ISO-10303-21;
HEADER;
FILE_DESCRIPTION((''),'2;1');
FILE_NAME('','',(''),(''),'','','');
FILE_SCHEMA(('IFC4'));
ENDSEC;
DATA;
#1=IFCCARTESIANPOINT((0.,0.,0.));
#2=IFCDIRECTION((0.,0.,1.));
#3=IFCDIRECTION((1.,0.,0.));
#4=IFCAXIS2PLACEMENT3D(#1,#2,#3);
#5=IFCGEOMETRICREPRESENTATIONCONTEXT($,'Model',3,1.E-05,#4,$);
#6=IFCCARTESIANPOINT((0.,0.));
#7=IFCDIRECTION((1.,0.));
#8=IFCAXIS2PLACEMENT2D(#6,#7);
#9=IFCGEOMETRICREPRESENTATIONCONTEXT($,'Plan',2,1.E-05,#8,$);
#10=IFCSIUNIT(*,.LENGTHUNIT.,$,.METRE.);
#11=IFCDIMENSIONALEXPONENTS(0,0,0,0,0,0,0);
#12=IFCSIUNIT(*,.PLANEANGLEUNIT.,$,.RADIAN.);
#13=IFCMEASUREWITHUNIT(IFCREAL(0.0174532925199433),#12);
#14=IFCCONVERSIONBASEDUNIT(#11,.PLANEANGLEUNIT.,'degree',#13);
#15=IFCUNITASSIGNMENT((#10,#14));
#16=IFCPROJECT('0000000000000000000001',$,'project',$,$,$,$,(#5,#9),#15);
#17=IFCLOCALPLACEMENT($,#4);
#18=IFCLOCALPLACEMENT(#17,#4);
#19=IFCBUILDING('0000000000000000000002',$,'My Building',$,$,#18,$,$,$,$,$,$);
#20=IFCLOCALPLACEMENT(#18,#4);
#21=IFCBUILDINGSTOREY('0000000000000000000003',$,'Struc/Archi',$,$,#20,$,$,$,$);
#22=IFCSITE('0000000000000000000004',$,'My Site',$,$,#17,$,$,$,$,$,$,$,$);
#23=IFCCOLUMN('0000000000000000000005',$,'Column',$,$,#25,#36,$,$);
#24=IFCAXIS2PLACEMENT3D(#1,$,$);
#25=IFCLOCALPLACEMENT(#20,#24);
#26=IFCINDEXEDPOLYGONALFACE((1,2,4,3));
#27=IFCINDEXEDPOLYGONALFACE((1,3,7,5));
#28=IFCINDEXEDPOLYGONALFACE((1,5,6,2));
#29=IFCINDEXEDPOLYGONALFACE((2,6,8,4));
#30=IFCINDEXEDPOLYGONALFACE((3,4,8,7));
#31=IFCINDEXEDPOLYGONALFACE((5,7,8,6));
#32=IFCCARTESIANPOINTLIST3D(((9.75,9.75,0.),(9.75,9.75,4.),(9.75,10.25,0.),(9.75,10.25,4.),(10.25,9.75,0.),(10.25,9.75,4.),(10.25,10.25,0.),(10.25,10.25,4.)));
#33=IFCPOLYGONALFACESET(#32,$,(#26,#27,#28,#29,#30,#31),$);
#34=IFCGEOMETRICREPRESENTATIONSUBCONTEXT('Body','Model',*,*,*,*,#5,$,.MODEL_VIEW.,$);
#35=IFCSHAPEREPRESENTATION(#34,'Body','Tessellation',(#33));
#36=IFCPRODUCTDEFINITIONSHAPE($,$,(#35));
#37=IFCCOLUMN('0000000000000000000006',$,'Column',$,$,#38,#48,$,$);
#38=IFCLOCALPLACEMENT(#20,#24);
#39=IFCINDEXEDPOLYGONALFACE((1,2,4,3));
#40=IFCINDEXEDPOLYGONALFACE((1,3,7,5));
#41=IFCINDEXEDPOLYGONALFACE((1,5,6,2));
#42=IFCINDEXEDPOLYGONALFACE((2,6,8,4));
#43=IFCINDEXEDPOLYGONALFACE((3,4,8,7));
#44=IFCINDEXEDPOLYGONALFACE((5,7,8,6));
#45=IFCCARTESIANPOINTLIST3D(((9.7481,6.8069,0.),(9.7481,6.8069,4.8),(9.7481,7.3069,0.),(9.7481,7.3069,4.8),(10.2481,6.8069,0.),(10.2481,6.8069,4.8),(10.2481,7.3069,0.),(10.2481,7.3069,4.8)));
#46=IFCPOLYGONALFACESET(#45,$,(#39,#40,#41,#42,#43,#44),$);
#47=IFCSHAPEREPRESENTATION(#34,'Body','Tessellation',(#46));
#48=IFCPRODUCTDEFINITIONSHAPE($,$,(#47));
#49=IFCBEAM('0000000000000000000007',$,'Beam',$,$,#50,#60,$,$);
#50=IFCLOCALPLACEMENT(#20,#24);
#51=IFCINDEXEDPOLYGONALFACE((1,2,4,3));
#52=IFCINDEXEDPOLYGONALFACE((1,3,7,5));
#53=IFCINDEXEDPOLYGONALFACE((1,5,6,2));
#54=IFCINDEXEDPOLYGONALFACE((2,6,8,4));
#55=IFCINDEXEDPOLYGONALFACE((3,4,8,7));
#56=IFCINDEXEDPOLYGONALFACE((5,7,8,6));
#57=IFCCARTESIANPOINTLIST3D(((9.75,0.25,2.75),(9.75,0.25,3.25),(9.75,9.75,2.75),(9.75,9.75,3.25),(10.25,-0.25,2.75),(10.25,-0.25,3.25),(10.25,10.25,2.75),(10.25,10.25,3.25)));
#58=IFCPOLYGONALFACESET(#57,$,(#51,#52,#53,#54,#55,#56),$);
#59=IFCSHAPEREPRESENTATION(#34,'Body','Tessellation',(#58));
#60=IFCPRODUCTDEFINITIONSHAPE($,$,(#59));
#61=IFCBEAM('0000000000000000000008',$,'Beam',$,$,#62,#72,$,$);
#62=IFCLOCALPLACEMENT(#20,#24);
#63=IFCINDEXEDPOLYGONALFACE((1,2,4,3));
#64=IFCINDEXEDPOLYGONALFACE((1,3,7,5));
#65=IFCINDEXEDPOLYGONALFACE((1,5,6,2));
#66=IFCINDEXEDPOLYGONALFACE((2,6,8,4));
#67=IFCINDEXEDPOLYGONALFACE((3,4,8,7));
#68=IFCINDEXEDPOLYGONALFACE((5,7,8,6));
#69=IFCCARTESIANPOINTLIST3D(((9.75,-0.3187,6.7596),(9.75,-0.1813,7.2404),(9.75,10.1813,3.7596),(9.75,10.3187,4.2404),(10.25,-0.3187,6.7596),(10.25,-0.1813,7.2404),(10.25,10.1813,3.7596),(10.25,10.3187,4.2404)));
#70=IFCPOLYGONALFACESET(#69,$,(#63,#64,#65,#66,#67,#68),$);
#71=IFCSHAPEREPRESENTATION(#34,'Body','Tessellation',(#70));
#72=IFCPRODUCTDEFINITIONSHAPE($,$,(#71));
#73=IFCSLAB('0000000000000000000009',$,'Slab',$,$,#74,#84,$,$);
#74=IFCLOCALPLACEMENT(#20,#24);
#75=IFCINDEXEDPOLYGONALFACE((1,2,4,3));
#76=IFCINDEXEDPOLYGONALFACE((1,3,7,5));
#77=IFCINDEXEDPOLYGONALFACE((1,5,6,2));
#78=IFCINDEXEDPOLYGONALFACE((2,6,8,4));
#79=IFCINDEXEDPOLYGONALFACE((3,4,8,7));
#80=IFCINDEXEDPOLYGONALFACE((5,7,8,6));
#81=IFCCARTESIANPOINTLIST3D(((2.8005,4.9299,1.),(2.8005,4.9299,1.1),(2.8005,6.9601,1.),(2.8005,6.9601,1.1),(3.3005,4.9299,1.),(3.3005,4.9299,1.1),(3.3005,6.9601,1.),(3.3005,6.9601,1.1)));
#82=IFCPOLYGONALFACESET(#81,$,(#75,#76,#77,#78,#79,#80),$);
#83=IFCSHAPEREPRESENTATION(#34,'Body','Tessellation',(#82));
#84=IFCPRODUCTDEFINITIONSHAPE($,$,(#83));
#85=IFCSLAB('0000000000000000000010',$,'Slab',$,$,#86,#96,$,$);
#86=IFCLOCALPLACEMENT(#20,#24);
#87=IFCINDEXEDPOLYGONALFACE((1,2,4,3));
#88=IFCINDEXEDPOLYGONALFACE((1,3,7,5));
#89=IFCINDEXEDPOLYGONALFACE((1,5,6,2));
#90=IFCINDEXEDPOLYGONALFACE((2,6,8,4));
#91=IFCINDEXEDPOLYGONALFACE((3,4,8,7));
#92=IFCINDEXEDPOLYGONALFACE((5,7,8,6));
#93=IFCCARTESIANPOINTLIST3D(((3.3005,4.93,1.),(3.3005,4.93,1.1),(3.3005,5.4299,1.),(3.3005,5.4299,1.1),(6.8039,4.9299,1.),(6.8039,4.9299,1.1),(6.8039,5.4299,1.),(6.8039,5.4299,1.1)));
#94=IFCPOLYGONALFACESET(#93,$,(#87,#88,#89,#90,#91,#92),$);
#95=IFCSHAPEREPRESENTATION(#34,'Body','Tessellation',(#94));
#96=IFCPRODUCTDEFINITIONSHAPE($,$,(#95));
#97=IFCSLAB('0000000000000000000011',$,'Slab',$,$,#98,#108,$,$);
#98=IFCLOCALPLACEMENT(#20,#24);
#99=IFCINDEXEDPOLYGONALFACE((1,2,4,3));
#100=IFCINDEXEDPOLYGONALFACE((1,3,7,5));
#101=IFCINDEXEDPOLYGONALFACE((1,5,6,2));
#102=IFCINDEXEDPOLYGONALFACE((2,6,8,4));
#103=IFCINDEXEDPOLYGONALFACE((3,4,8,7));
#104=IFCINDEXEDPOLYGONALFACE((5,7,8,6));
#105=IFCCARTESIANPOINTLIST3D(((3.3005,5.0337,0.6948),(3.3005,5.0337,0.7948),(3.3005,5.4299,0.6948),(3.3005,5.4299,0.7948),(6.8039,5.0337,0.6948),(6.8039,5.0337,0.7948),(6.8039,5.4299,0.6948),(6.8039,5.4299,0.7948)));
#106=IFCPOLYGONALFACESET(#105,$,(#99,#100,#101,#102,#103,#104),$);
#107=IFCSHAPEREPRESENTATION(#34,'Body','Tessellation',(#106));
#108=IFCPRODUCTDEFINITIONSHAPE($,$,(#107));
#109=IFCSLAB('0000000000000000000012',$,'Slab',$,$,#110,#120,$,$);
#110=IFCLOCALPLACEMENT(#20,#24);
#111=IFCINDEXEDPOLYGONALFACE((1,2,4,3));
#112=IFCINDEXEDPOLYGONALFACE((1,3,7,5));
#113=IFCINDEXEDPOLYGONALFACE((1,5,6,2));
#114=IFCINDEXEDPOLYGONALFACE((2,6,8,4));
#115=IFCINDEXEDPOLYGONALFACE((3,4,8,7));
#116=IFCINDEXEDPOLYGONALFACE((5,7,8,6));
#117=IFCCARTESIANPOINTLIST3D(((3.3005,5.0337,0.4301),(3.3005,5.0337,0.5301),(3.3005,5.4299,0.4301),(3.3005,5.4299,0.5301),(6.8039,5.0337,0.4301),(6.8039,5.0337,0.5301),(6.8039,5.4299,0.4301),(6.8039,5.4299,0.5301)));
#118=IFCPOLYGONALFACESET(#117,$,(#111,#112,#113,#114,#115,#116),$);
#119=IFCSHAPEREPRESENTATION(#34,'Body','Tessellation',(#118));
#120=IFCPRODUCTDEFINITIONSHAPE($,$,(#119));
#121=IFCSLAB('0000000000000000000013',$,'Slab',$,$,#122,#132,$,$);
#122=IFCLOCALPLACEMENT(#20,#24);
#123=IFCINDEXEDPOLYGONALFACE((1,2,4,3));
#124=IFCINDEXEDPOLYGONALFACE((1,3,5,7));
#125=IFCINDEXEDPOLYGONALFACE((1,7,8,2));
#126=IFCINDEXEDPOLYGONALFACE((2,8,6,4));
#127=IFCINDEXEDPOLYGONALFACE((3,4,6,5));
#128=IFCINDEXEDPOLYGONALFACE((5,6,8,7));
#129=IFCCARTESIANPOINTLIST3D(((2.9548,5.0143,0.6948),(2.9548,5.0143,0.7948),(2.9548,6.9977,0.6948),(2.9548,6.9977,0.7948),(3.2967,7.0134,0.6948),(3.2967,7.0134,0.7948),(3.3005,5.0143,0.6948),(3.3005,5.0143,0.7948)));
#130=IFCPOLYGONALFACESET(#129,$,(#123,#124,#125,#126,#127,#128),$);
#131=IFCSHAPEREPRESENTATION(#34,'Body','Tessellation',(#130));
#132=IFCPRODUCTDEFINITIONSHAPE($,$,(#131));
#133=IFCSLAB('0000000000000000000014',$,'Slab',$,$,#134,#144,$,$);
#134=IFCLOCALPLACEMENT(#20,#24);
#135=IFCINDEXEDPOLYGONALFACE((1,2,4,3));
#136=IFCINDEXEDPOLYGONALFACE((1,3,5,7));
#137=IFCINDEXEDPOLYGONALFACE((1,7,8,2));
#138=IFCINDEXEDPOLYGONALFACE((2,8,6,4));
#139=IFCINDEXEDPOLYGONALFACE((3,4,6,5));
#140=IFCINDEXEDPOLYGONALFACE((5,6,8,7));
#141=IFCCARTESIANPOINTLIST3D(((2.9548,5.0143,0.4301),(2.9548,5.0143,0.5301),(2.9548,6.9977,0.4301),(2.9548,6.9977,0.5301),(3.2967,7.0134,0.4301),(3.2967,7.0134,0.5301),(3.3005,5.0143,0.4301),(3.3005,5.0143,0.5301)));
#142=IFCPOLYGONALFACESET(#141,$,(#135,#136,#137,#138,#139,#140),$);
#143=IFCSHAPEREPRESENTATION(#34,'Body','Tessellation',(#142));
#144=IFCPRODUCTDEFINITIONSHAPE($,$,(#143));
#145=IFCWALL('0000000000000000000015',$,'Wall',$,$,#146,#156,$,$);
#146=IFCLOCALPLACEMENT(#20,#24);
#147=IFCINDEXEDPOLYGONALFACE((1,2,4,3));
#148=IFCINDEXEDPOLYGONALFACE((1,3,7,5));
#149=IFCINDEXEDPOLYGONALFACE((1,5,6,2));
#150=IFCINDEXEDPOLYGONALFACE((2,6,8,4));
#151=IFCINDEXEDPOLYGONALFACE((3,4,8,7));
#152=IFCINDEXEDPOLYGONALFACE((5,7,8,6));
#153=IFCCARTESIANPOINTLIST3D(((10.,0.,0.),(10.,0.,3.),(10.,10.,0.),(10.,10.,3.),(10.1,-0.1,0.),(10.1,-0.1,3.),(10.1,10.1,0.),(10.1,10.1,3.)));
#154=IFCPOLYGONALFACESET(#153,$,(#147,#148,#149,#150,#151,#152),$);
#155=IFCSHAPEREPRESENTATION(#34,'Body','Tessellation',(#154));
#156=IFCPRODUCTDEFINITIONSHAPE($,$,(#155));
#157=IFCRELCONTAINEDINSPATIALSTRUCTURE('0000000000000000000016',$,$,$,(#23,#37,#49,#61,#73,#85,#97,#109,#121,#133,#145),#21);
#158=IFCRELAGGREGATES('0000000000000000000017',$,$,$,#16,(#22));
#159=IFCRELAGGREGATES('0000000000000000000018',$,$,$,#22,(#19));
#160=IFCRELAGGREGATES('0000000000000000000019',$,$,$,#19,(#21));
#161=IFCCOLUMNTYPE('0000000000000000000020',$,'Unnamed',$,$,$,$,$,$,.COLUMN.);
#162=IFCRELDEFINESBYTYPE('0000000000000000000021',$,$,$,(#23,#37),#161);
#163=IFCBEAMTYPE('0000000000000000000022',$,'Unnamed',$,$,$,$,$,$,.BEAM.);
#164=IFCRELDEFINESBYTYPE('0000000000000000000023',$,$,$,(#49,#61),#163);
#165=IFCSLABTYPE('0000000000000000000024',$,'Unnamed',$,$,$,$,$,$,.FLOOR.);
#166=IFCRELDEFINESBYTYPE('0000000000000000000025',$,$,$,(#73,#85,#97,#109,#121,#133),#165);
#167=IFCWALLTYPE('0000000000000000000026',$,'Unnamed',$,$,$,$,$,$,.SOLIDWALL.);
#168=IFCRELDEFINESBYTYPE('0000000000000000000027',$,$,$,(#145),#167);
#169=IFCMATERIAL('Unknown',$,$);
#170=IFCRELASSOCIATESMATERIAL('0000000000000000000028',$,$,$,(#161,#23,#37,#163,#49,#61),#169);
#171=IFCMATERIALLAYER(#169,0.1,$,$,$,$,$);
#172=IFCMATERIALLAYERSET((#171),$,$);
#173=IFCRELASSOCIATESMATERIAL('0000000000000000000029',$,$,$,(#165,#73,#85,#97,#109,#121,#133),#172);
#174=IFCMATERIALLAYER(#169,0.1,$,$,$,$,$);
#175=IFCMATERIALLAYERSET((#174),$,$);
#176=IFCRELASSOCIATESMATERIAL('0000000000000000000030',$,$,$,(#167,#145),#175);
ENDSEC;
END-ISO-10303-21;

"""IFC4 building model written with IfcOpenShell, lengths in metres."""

from ifc_helpers import new_model, entity, si_unit, converted_unit, frame, origin_with_axes, origin_2d_with_axis, place, context, subcontext, project, spatial, line, indexed_curve, rectangle, outline, extrude, clip, halfspace, material, layer, layer_set, layer_usage, material_profile, profile_set, profile_usage, type_object, element, save


model = new_model("IFC4")

# Units and contexts
model_context = context("Model", 3, precision=1e-05, world=origin_with_axes())
plan_context = context("Plan", 2, precision=1e-05, world=origin_2d_with_axis())
body_context_1 = subcontext(model_context, "Body", "Model", "MODEL_VIEW")
ifc_project = project(units=[si_unit("LENGTHUNIT", "METRE"), converted_unit("PLANEANGLEUNIT", "degree", entity("IfcReal", 0.0174532925199433), si_unit("PLANEANGLEUNIT", "RADIAN"), dimensions=[0, 0, 0, 0, 0, 0, 0])], contexts=[model_context, plan_context])

# Site, building, storey
site_placement = place(None, origin_with_axes())
site = spatial("IfcSite", under=ifc_project, at=site_placement, Name="My Site")
building_placement = place(site_placement, origin_with_axes())
building = spatial("IfcBuilding", under=site, at=building_placement, Name="My Building")
storey_placement = place(building_placement, origin_with_axes())
storey = spatial("IfcBuildingStorey", under=building, at=storey_placement, Name="Struc/Archi")

# Columns
ifc_material = material(Name="Unknown")
ifc_material_profile_1 = material_profile(ifc_material, rectangle(XDim=0.5, YDim=0.5))
ifc_profile_set_1 = profile_set([ifc_material_profile_1])
ifc_profile_usage_1 = profile_usage(ifc_profile_set_1, cardinal=5)
column_type = type_object("IfcColumnType", Name="Unnamed", PredefinedType="COLUMN", material=ifc_profile_set_1)
column_1_placement = place(storey_placement, frame((10.0, 10.0, 0.0), z_axis=(0.0, 0.0, 1.0), x_axis=(1.0, 0.0, 0.0)))
element("IfcColumn", 1, at=column_1_placement, inside=storey, type_object=column_type, material=ifc_profile_usage_1, Name="Column", context=body_context_1, shape_type="SweptSolid", body=[
    extrude(rectangle(XDim=0.5, YDim=0.5), origin_with_axes(), (0.0, 0.0, 1.0), 4.0),
])
ifc_profile_usage_2 = profile_usage(ifc_profile_set_1, cardinal=5)
column_2_placement = place(storey_placement, frame((9.9981, 7.0569, 0.0), z_axis=(0.0, 0.0, 1.0), x_axis=(1.0, 0.0, 0.0)))
element("IfcColumn", 2, at=column_2_placement, inside=storey, type_object=column_type, material=ifc_profile_usage_2, Name="Column", context=body_context_1, shape_type="SweptSolid", body=[
    extrude(rectangle(XDim=0.5, YDim=0.5), origin_with_axes(), (0.0, 0.0, 1.0), 4.8),
])

# Beams
ifc_material_profile_2 = material_profile(ifc_material, rectangle(XDim=0.5, YDim=0.5))
ifc_profile_set_2 = profile_set([ifc_material_profile_2])
ifc_profile_usage_3 = profile_usage(ifc_profile_set_2, cardinal=5)
beam_type = type_object("IfcBeamType", Name="Unnamed", PredefinedType="BEAM", material=ifc_profile_set_2)
beam_1_placement = place(storey_placement, frame((10.0, 10.25, 3.0), z_axis=(0.0, -1.0, 0.0), x_axis=(1.0, 0.0, 0.0)))
element("IfcBeam", 3, at=beam_1_placement, inside=storey, type_object=beam_type, material=ifc_profile_usage_3, Name="Beam", context=body_context_1, shape_type="Clipping", body=[
    clip(clip(extrude(rectangle(XDim=0.5, YDim=0.5), origin_with_axes(), (0.0, 0.0, 1.0), 10.5), halfspace(frame((0.25, -3.0, 10.5), z_axis=(-0.707107, 0.0, 0.707107), x_axis=(0.0, 1.0, 0.0)), False)), halfspace(frame((0.25, -3.0, 0.0), z_axis=(-0.707107, 0.0, -0.707107), x_axis=(0.0, 1.0, 0.0)), False)),
])
ifc_profile_usage_4 = profile_usage(ifc_profile_set_2, cardinal=5)
beam_2_placement = place(storey_placement, frame((10.0, 10.25, 4.0), z_axis=(0.0, -0.961524, 0.274721), x_axis=(1.0, 0.0, 0.0)))
element("IfcBeam", 4, at=beam_2_placement, inside=storey, type_object=beam_type, material=ifc_profile_usage_4, Name="Beam", context=body_context_1, shape_type="SweptSolid", body=[
    extrude(rectangle(XDim=0.5, YDim=0.5), origin_with_axes(), (0.0, 0.0, 1.0), 10.9202),
])

# Slabs
ifc_layer_1 = layer(ifc_material, 0.1)
ifc_layer_set_1 = layer_set([ifc_layer_1])
ifc_layer_usage_1 = layer_usage(ifc_layer_set_1, "AXIS3", "POSITIVE", -0.1)
slab_type = type_object("IfcSlabType", Name="Unnamed", PredefinedType="FLOOR", material=ifc_layer_set_1)
slab_1_placement = place(storey_placement, frame((2.8005, 6.9601, 1.1), z_axis=(0.0, 0.0, 1.0), x_axis=(1.0, 0.0, 0.0)))
element("IfcSlab", 5, at=slab_1_placement, inside=storey, type_object=slab_type, material=ifc_layer_usage_1, Name="Slab", context=body_context_1, shape_type="SweptSolid", body=[
    extrude(outline(indexed_curve([(0.0, 0.0), (0.5, 0.0), (0.5, -2.0301), (0.0, -2.0301), (0.0, 0.0)])), frame((0.0, 0.0, -0.1), z_axis=(0.0, 0.0, 1.0), x_axis=(1.0, 0.0, 0.0)), (0.0, 0.0, 1.0), 0.1),
])
ifc_layer_usage_2 = layer_usage(ifc_layer_set_1, "AXIS3", "POSITIVE", -0.1)
slab_2_placement = place(storey_placement, frame((6.8039, 4.9299, 1.1), z_axis=(0.0, 0.0, 1.0), x_axis=(1.0, 0.0, 0.0)))
element("IfcSlab", 6, at=slab_2_placement, inside=storey, type_object=slab_type, material=ifc_layer_usage_2, Name="Slab", context=body_context_1, shape_type="SweptSolid", body=[
    extrude(outline(indexed_curve([(0.0, 0.0), (0.0, 0.5), (-3.5034, 0.5), (-3.5034, 0.0001), (0.0, 0.0)])), frame((0.0, 0.0, -0.1), z_axis=(0.0, 0.0, 1.0), x_axis=(1.0, 0.0, 0.0)), (0.0, 0.0, 1.0), 0.1),
])
ifc_layer_usage_3 = layer_usage(ifc_layer_set_1, "AXIS3", "POSITIVE", -0.1)
slab_3_placement = place(storey_placement, frame((3.3005, 5.4299, 0.7948), z_axis=(0.0, 0.0, 1.0), x_axis=(1.0, 0.0, 0.0)))
element("IfcSlab", 7, at=slab_3_placement, inside=storey, type_object=slab_type, material=ifc_layer_usage_3, Name="Slab", context=body_context_1, shape_type="SweptSolid", body=[
    extrude(outline(indexed_curve([(0.0, 0.0), (3.5034, 0.0), (3.5034, -0.3962), (0.0, -0.3962), (0.0, 0.0)])), frame((0.0, 0.0, -0.1), z_axis=(0.0, 0.0, 1.0), x_axis=(1.0, 0.0, 0.0)), (0.0, 0.0, 1.0), 0.1),
])
ifc_layer_usage_4 = layer_usage(ifc_layer_set_1, "AXIS3", "POSITIVE", -0.1)
slab_4_placement = place(storey_placement, frame((3.3005, 5.4299, 0.5301), z_axis=(0.0, 0.0, 1.0), x_axis=(1.0, 0.0, 0.0)))
element("IfcSlab", 8, at=slab_4_placement, inside=storey, type_object=slab_type, material=ifc_layer_usage_4, Name="Slab", context=body_context_1, shape_type="SweptSolid", body=[
    extrude(outline(indexed_curve([(0.0, 0.0), (3.5034, 0.0), (3.5034, -0.3962), (0.0, -0.3962), (0.0, 0.0)])), frame((0.0, 0.0, -0.1), z_axis=(0.0, 0.0, 1.0), x_axis=(1.0, 0.0, 0.0)), (0.0, 0.0, 1.0), 0.1),
])
ifc_layer_usage_5 = layer_usage(ifc_layer_set_1, "AXIS3", "POSITIVE", -0.1)
slab_5_placement = place(storey_placement, frame((3.2967, 7.0134, 0.7948), z_axis=(0.0, 0.0, 1.0), x_axis=(1.0, 0.0, 0.0)))
element("IfcSlab", 9, at=slab_5_placement, inside=storey, type_object=slab_type, material=ifc_layer_usage_5, Name="Slab", context=body_context_1, shape_type="SweptSolid", body=[
    extrude(outline(indexed_curve([(0.0, 0.0), (0.0038, -1.9991), (-0.3419, -1.9991), (-0.3419, -0.0157), (0.0, 0.0)])), frame((0.0, 0.0, -0.1), z_axis=(0.0, 0.0, 1.0), x_axis=(1.0, 0.0, 0.0)), (0.0, 0.0, 1.0), 0.1),
])
ifc_layer_usage_6 = layer_usage(ifc_layer_set_1, "AXIS3", "POSITIVE", -0.1)
slab_6_placement = place(storey_placement, frame((3.2967, 7.0134, 0.5301), z_axis=(0.0, 0.0, 1.0), x_axis=(1.0, 0.0, 0.0)))
element("IfcSlab", 10, at=slab_6_placement, inside=storey, type_object=slab_type, material=ifc_layer_usage_6, Name="Slab", context=body_context_1, shape_type="SweptSolid", body=[
    extrude(outline(indexed_curve([(0.0, 0.0), (0.0038, -1.9991), (-0.3419, -1.9991), (-0.3419, -0.0157), (0.0, 0.0)])), frame((0.0, 0.0, -0.1), z_axis=(0.0, 0.0, 1.0), x_axis=(1.0, 0.0, 0.0)), (0.0, 0.0, 1.0), 0.1),
])

# Wall
ifc_layer_2 = layer(ifc_material, 0.1)
ifc_layer_set_2 = layer_set([ifc_layer_2])
ifc_layer_usage_7 = layer_usage(ifc_layer_set_2, "AXIS2", "POSITIVE", 0.0)
wall_type = type_object("IfcWallType", Name="Unnamed", PredefinedType="SOLIDWALL", material=ifc_layer_set_2)
wall_1_placement = place(storey_placement, frame((10.0, 10.0, 0.0), z_axis=(0.0, 0.0, 1.0), x_axis=(0.0, -1.0, 0.0)))
element("IfcWall", 11, at=wall_1_placement, inside=storey, type_object=wall_type, material=ifc_layer_usage_7, Name="Wall", context=body_context_1, shape_type="SweptSolid", body=[
    extrude(outline(indexed_curve([(0.0, 0.0), (-0.1, 0.1), (10.1, 0.1), (10.0, 0.0)], segments=[line(1, 2, 3, 4, 1)])), origin_with_axes(), (0.0, 0.0, 1.0), 3.0),
])

save(model, "model.ifc")
